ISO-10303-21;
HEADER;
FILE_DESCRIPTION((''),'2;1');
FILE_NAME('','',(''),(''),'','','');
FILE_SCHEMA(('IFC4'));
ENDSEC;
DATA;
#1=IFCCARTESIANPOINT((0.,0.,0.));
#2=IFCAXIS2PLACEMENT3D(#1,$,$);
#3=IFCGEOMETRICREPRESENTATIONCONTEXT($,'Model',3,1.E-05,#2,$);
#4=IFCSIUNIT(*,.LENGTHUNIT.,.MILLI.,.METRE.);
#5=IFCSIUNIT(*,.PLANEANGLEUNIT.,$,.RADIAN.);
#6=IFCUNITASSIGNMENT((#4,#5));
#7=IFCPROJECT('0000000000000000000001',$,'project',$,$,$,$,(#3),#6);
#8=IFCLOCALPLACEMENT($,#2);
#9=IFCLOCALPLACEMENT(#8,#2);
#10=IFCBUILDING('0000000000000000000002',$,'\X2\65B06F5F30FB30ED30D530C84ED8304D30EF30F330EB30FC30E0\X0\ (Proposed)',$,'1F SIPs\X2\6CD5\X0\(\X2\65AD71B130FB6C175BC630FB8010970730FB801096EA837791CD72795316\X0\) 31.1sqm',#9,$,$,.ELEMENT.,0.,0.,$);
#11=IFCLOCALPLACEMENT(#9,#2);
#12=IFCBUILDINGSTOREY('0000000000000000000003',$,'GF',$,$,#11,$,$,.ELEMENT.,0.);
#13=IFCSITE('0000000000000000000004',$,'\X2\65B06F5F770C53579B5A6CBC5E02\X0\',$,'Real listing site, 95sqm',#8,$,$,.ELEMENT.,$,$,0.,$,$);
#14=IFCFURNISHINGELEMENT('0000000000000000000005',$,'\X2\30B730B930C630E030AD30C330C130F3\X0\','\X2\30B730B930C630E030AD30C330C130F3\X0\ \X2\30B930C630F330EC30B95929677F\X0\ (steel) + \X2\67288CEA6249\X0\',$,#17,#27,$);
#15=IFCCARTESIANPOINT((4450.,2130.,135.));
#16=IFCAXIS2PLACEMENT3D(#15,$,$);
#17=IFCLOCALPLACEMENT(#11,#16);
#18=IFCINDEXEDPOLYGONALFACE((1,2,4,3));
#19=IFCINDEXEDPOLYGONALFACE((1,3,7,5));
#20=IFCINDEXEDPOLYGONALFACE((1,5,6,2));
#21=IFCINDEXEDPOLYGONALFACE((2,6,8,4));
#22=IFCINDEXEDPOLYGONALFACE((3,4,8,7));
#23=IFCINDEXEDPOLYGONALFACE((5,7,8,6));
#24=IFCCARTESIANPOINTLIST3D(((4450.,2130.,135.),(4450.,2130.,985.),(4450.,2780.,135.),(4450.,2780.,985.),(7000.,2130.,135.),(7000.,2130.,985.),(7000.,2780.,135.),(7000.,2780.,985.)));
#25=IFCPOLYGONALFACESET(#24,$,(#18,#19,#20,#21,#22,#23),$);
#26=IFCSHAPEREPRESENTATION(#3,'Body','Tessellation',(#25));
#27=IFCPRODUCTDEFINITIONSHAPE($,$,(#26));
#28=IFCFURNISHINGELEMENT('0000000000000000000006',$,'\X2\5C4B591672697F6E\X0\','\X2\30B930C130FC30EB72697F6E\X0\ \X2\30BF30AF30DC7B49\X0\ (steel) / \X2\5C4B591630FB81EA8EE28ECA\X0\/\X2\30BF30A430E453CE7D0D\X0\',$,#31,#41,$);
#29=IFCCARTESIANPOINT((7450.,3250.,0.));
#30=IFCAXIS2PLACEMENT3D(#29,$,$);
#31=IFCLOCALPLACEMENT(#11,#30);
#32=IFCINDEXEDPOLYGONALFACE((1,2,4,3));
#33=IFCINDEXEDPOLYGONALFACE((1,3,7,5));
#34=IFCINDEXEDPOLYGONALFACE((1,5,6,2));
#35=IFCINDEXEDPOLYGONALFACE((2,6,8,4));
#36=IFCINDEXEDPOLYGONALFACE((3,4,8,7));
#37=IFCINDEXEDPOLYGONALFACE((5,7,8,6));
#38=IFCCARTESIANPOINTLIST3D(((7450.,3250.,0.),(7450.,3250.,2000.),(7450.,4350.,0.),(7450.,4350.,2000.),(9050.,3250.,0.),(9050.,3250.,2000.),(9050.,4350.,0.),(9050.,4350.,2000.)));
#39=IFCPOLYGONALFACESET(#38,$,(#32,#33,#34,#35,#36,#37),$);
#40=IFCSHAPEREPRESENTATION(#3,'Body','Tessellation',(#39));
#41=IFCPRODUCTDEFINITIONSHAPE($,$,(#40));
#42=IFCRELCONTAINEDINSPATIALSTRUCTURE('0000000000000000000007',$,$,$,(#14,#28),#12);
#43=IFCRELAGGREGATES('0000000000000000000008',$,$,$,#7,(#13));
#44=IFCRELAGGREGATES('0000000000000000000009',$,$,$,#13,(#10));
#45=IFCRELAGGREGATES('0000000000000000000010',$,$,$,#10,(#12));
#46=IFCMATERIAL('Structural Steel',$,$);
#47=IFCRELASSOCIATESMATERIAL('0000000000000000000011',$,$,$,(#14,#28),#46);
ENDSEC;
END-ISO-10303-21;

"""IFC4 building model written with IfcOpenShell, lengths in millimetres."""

from ifc_helpers import new_model, si_unit, frame, frame_2d, origin, place, context, project, spatial, rectangle, extrude, material, element, save


model = new_model("IFC4")

# Units and contexts
model_context = context("Model", 3, precision=1e-05, world=origin())
ifc_project = project(units=[si_unit("LENGTHUNIT", "METRE", prefix="MILLI"), si_unit("PLANEANGLEUNIT", "RADIAN")], contexts=[model_context])

# Site, building, storey
site_placement = place(None, origin())
site = spatial("IfcSite", under=ifc_project, at=site_placement, Name="新潟県南魚沼市", ObjectType="Real listing site, 95sqm", CompositionType="ELEMENT", RefElevation=0.0)
building_placement = place(site_placement, origin())
building = spatial("IfcBuilding", under=site, at=building_placement, Name="新潟・ロフト付きワンルーム (Proposed)", ObjectType="1F SIPs法(断熱・気密・耐震・耐雪荷重特化) 31.1sqm", CompositionType="ELEMENT", ElevationOfRefHeight=0.0, ElevationOfTerrain=0.0)
storey_placement = place(building_placement, origin())
storey = spatial("IfcBuildingStorey", under=building, at=storey_placement, Name="GF", CompositionType="ELEMENT", Elevation=0.0)

# Shared definitions
ifc_material_1 = material(Name="Structural Steel")

# Furnishing elements
furnishing_1_placement = place(storey_placement, frame((4450.0, 2130.0, 135.0)))
element("IfcFurnishingElement", 1, at=furnishing_1_placement, inside=storey, material=ifc_material_1, Name="システムキッチン", Description="システムキッチン ステンレス天板 (steel) + 木質扉", context=model_context, shape_type="SweptSolid", body=[
    extrude(rectangle(XDim=2550.0, YDim=650.0, at=frame_2d((1275.0, 325.0))), frame((4450.0, 2130.0, 135.0)), (0.0, 0.0, 1.0), 850.0),
])
furnishing_2_placement = place(storey_placement, frame((7450.0, 3250.0, 0.0)))
element("IfcFurnishingElement", 2, at=furnishing_2_placement, inside=storey, material=ifc_material_1, Name="屋外物置", Description="スチール物置 タクボ等 (steel) / 屋外・自転車/タイヤ収納", context=model_context, shape_type="SweptSolid", body=[
    extrude(rectangle(XDim=1600.0, YDim=1100.0, at=frame_2d((800.0, 550.0))), frame((7450.0, 3250.0, 0.0)), (0.0, 0.0, 1.0), 2000.0),
])

save(model, "model.ifc")
